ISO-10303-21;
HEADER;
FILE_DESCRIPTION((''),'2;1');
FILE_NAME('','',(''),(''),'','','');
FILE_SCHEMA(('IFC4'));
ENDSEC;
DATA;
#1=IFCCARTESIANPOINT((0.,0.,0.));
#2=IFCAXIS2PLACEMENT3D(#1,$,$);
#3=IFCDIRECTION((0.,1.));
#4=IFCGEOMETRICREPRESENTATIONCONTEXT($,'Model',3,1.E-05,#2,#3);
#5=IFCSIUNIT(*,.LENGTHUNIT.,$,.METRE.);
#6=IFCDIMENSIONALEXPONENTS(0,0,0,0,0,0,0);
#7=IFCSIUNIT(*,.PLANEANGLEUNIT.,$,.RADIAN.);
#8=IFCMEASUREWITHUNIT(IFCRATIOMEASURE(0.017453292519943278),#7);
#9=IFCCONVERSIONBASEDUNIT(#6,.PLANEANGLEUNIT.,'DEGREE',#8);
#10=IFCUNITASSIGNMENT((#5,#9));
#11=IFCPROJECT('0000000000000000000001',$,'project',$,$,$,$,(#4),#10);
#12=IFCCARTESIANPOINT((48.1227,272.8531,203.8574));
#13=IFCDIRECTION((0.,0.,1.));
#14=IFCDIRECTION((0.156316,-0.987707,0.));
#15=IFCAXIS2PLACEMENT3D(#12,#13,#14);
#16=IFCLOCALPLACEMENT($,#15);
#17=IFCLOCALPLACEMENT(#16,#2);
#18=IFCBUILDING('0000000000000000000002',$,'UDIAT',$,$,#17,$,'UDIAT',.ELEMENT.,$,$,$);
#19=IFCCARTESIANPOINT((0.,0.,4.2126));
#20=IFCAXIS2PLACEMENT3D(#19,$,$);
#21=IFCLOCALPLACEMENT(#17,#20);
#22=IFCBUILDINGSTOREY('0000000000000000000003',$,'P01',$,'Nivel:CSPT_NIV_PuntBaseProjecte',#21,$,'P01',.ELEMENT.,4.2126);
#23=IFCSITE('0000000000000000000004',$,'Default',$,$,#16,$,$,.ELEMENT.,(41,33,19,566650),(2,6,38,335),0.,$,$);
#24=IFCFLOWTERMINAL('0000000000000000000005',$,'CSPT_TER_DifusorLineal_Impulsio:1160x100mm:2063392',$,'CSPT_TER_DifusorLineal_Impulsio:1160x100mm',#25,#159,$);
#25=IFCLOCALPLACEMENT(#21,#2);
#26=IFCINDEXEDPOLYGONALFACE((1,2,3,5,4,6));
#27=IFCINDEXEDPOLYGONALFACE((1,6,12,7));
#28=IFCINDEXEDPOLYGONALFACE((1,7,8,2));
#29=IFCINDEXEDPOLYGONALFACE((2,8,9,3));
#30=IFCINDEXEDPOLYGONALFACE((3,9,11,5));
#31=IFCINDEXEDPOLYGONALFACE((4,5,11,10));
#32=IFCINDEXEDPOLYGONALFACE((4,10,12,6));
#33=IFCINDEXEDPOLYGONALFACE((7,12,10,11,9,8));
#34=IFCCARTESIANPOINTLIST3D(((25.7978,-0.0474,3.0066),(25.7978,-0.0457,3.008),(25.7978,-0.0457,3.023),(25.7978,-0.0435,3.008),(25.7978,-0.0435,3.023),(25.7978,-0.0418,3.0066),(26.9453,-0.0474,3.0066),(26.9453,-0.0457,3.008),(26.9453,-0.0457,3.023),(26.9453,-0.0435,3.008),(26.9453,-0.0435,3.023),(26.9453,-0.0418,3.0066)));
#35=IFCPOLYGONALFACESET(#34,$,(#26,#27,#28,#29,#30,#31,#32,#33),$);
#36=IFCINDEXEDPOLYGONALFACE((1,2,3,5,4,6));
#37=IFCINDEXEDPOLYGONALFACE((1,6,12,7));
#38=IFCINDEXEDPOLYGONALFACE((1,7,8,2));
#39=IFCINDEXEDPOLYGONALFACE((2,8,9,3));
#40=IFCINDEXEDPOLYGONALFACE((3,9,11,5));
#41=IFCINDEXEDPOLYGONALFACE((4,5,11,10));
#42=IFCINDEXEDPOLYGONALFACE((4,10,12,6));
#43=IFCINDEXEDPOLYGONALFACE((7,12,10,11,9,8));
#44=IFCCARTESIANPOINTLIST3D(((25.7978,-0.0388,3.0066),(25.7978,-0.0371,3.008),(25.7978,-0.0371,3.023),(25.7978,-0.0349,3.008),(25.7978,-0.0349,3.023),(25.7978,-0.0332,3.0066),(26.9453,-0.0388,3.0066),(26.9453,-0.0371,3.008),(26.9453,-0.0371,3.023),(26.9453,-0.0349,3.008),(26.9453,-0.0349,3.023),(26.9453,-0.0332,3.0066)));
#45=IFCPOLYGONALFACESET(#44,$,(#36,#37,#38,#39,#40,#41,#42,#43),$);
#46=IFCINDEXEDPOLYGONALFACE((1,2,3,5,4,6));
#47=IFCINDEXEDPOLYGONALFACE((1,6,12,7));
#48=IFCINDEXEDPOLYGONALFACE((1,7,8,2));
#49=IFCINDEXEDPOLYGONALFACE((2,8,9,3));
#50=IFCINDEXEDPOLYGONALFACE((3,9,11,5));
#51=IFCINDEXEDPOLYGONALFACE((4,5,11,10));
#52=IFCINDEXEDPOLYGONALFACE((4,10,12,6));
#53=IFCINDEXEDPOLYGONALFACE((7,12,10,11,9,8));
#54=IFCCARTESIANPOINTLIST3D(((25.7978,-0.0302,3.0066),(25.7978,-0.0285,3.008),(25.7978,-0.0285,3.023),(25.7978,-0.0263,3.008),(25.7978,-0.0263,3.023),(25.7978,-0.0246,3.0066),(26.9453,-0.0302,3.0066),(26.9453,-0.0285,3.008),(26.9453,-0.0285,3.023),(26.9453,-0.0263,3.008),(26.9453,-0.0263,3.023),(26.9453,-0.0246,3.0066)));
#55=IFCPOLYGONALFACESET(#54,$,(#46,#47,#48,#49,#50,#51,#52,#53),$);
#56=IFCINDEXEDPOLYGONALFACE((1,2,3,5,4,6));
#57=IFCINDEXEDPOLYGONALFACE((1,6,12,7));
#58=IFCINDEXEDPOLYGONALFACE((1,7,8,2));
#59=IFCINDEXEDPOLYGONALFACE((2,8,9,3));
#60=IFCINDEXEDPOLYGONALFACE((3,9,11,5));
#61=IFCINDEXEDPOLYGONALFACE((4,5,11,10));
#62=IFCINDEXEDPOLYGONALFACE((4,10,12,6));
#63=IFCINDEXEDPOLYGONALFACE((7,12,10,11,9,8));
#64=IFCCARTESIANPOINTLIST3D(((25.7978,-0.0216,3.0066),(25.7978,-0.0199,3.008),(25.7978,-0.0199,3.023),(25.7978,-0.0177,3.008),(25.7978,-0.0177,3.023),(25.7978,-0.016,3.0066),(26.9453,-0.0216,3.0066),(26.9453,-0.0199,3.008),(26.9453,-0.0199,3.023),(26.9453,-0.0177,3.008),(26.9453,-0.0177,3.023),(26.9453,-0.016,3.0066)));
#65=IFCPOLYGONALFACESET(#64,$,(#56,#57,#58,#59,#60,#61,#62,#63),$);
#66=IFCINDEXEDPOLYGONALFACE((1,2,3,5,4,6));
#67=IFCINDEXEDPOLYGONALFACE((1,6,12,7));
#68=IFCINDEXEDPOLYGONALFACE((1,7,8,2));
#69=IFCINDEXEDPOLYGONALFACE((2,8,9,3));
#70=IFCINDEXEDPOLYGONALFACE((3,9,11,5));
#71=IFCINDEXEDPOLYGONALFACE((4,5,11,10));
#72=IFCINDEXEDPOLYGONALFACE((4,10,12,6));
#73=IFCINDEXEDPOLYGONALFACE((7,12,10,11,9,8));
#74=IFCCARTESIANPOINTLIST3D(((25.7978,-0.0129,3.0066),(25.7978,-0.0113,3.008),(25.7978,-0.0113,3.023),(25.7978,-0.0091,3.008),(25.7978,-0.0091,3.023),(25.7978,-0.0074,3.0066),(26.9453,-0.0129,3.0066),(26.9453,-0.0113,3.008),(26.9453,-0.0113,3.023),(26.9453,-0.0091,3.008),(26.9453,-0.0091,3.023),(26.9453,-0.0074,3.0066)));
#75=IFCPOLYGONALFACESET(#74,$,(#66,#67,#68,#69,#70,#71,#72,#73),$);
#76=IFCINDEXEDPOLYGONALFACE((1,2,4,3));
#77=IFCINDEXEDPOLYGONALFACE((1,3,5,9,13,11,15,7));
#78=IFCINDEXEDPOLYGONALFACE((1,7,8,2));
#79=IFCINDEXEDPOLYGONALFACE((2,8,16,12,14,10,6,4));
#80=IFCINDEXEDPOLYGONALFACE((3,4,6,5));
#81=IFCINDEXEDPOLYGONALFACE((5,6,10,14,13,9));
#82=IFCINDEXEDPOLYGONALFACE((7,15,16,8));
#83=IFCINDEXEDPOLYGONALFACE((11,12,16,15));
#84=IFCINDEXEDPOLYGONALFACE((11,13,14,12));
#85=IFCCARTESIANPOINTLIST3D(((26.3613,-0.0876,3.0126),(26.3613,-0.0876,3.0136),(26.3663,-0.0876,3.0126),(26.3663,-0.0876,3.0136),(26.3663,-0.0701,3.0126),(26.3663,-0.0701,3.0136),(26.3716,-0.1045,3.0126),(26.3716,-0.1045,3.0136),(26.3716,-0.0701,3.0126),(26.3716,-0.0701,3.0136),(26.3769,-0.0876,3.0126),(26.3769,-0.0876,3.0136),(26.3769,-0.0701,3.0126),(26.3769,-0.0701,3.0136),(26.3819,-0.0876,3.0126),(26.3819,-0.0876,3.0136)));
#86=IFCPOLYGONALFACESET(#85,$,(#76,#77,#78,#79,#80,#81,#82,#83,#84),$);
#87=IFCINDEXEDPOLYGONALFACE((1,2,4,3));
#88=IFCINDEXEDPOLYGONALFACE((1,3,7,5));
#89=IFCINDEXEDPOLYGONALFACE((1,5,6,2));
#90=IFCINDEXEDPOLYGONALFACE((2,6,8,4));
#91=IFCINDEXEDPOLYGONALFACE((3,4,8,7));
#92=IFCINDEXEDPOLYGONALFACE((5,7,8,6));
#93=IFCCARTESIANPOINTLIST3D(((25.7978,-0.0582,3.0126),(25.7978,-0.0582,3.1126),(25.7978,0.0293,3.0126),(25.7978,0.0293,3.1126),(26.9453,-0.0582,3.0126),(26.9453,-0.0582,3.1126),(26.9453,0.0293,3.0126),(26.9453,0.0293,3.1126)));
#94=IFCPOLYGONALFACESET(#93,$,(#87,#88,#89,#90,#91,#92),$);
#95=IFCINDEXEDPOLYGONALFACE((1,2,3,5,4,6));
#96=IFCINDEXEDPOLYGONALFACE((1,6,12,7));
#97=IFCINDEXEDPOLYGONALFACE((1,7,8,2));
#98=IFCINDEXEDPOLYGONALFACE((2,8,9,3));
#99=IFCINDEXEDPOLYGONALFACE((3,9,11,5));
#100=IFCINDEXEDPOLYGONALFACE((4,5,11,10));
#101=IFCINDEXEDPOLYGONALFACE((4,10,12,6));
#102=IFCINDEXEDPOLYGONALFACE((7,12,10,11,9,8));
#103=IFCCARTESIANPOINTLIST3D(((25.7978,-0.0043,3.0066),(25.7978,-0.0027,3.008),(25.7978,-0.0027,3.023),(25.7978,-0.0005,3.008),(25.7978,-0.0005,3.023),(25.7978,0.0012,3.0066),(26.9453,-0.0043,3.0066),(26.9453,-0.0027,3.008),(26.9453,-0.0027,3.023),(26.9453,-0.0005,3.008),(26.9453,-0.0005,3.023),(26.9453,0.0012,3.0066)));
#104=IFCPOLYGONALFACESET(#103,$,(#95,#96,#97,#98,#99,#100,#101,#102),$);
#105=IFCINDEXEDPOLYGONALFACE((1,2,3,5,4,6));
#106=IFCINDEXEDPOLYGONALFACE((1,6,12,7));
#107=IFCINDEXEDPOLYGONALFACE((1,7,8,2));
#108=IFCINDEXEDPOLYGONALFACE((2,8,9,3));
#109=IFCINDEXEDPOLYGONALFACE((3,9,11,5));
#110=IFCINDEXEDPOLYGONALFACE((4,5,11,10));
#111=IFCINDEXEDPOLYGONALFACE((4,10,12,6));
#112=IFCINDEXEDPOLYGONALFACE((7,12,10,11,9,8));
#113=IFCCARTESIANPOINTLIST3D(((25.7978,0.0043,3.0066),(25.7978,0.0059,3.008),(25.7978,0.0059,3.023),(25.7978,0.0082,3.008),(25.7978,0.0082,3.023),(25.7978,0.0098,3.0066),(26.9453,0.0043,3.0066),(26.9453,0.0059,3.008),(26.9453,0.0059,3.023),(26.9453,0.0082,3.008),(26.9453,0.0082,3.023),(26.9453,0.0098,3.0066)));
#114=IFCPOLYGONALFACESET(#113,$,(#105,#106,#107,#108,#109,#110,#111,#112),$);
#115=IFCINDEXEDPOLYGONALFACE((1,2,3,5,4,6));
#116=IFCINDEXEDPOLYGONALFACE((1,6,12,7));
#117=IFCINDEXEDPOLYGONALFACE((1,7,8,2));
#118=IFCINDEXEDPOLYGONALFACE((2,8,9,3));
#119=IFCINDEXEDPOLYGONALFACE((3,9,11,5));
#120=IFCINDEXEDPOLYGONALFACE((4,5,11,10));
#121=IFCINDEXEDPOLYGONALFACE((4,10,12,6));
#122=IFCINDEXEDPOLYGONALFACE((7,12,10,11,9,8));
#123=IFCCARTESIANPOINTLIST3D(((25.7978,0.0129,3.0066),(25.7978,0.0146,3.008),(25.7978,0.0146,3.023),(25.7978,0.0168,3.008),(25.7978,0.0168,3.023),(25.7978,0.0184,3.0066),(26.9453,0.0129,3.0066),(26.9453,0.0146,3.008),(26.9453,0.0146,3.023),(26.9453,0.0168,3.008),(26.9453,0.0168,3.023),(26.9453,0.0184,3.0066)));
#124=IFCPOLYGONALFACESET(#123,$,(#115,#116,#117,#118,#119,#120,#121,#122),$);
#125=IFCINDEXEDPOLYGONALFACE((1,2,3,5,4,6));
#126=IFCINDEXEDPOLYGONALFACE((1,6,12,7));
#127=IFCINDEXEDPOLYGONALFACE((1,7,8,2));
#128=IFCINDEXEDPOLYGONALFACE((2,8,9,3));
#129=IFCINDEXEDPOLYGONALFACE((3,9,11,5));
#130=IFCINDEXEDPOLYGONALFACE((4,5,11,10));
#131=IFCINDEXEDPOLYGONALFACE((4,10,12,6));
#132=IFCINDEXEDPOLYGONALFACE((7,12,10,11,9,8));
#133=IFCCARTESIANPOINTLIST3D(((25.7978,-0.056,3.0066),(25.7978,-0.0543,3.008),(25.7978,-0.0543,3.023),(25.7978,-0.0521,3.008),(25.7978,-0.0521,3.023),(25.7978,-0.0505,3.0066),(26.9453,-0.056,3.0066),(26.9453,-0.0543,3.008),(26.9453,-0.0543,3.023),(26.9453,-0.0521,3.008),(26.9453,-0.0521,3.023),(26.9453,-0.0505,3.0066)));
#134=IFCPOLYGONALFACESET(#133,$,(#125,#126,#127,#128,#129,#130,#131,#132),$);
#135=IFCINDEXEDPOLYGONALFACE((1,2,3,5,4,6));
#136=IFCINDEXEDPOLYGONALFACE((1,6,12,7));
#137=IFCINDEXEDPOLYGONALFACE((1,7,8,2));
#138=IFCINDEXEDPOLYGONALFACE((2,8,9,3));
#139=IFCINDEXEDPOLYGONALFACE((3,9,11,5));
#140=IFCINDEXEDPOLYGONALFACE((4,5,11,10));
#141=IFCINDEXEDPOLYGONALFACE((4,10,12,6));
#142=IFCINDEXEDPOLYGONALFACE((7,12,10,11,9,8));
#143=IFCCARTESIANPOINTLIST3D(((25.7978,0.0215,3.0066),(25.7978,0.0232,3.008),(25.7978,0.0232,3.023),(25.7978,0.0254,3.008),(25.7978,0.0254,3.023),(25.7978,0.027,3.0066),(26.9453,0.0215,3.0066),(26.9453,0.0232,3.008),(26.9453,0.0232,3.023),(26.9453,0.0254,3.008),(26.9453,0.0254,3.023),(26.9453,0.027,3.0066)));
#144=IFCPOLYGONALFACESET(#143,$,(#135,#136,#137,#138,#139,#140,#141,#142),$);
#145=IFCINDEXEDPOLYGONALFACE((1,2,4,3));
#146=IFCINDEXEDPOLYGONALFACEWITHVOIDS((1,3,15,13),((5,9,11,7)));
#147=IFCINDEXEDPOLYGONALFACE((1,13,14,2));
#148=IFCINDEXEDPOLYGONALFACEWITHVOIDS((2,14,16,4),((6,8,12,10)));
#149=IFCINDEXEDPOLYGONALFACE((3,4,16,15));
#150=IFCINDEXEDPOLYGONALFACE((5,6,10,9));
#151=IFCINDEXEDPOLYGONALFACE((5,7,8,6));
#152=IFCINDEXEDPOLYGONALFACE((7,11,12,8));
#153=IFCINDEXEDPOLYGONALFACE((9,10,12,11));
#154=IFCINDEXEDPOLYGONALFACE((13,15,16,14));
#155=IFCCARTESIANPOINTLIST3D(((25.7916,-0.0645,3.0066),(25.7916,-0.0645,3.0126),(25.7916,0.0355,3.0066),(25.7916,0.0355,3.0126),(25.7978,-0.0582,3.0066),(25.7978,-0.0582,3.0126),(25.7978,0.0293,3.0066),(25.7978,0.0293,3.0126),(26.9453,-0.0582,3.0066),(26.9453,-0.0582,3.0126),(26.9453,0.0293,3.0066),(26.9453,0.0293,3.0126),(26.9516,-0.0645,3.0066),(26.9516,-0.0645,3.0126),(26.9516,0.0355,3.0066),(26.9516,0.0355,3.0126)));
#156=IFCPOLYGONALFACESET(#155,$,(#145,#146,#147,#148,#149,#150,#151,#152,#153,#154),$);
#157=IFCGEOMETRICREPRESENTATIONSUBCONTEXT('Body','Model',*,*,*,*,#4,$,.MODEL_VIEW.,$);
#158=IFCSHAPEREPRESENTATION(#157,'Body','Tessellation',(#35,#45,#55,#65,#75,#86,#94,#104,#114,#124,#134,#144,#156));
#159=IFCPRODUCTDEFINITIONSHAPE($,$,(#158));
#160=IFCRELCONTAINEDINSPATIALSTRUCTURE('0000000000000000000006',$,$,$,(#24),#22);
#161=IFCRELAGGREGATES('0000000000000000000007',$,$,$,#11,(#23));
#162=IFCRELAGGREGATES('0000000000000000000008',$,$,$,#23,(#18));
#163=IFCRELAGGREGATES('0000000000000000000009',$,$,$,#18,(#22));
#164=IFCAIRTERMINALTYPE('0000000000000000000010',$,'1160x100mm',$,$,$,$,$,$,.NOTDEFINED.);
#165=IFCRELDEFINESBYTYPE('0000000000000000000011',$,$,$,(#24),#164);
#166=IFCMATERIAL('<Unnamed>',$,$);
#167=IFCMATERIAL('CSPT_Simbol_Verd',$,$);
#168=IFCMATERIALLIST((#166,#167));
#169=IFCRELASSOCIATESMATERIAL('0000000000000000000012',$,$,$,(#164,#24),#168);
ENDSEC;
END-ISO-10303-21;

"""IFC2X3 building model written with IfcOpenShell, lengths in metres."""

from ifc_helpers import new_model, entity, si_unit, converted_unit, direction, frame, origin, origin_2d_with_axis, place, context, subcontext, project, spatial, polyline, rectangle, outline, extrude, source, transform, mapped, material, material_list, type_object, type_shapes, element, save


model = new_model("IFC2X3")

# Units and contexts
model_context = context("Model", 3, precision=1e-05, world=origin(), true_north=direction((0.0, 1.0)))
body_context = subcontext(model_context, "Body", "Model", "MODEL_VIEW")
ifc_project = project(units=[si_unit("LENGTHUNIT", "METRE"), converted_unit("PLANEANGLEUNIT", "DEGREE", entity("IfcRatioMeasure", 0.017453292519943278), si_unit("PLANEANGLEUNIT", "RADIAN"), dimensions=[0, 0, 0, 0, 0, 0, 0])], contexts=[model_context])

# Site, building, storey
site_placement = place(None, frame((48.1227, 272.8531, 203.8574), z_axis=(0.0, 0.0, 1.0), x_axis=(0.156316, -0.987707, 0.0)))
site = spatial("IfcSite", under=ifc_project, at=site_placement, Name="Default", CompositionType="ELEMENT", RefLatitude=(41, 33, 19, 566650), RefLongitude=(2, 6, 38, 335), RefElevation=0.0)
building_placement = place(site_placement, origin())
building = spatial("IfcBuilding", under=site, at=building_placement, Name="UDIAT", LongName="UDIAT", CompositionType="ELEMENT")
storey_placement = place(building_placement, frame((0.0, 0.0, 4.2126)))
storey = spatial("IfcBuildingStorey", under=building, at=storey_placement, Name="P01", ObjectType="Nivel:CSPT_NIV_PuntBaseProjecte", LongName="P01", CompositionType="ELEMENT", Elevation=4.2126)

# Shared definitions
ifc_material_1 = material(Name="<Unnamed>")

# Flow terminal
ifc_material_2 = material(Name="CSPT_Simbol_Verd")
ifc_material_list = material_list([ifc_material_1, ifc_material_2])
air_terminal_type = type_object("IfcAirTerminalType", Name="1160x100mm", PredefinedType="NOTDEFINED", material=ifc_material_list)
shared_shape_1 = source(origin(), body_context, "Body", "SweptSolid", [
    extrude(outline(polyline([(0.0037, 0.0028), (0.0059, 0.0028), (0.0016, 0.0063), (0.002, 0.0042), (-0.0074, -0.0074), (-0.0057, -0.0088), (0.0037, 0.0028)])), frame((-0.5737, 0.0301, -0.0001), z_axis=(1.0, 0.0, 0.0), x_axis=(0.0, -0.776119, -0.630587)), (0.0, 0.0, 1.0), 1.1475),
    extrude(outline(polyline([(0.0037, 0.0028), (0.0059, 0.0028), (0.0016, 0.0063), (0.002, 0.0042), (-0.0074, -0.0074), (-0.0057, -0.0088), (0.0037, 0.0028)])), frame((-0.5737, 0.0215, -0.0001), z_axis=(1.0, 0.0, 0.0), x_axis=(0.0, -0.776119, -0.630587)), (0.0, 0.0, 1.0), 1.1475),
    extrude(outline(polyline([(0.0037, 0.0028), (0.0059, 0.0028), (0.0016, 0.0063), (0.002, 0.0042), (-0.0074, -0.0074), (-0.0057, -0.0088), (0.0037, 0.0028)])), frame((-0.5737, 0.0129, -0.0001), z_axis=(1.0, 0.0, 0.0), x_axis=(0.0, -0.776119, -0.630587)), (0.0, 0.0, 1.0), 1.1475),
    extrude(outline(polyline([(0.0037, 0.0028), (0.0059, 0.0028), (0.0016, 0.0063), (0.002, 0.0042), (-0.0074, -0.0074), (-0.0057, -0.0088), (0.0037, 0.0028)])), frame((-0.5737, 0.0043, -0.0001), z_axis=(1.0, 0.0, 0.0), x_axis=(0.0, -0.776119, -0.630587)), (0.0, 0.0, 1.0), 1.1475),
    extrude(outline(polyline([(0.0037, 0.0028), (0.0059, 0.0028), (0.0016, 0.0063), (0.002, 0.0042), (-0.0074, -0.0074), (-0.0057, -0.0088), (0.0037, 0.0028)])), frame((-0.5737, -0.0043, -0.0001), z_axis=(1.0, 0.0, 0.0), x_axis=(0.0, -0.776119, -0.630587)), (0.0, 0.0, 1.0), 1.1475),
    extrude(outline(polyline([(0.0, -0.013), (0.0053, -0.013), (0.0053, 0.0045), (0.0103, 0.0045), (0.0, 0.0213), (-0.0103, 0.0045), (-0.0053, 0.0045), (-0.0053, -0.013), (0.0, -0.013)])), frame((0.0, 0.0687, 0.0)), (0.0, 0.0, 1.0), 0.001),
    extrude(rectangle(XDim=1.1475, YDim=0.0875, at=origin_2d_with_axis()), frame((0.0, 0.0, 0.0), z_axis=(0.0, 0.0, 1.0), x_axis=(-1.0, 0.0, 0.0)), (0.0, 0.0, 1.0), 0.1),
    extrude(outline(polyline([(0.0037, 0.0028), (0.0059, 0.0028), (0.0016, 0.0063), (0.002, 0.0042), (-0.0074, -0.0074), (-0.0057, -0.0088), (0.0037, 0.0028)])), frame((-0.5737, -0.0129, -0.0001), z_axis=(1.0, 0.0, 0.0), x_axis=(0.0, -0.776119, -0.630587)), (0.0, 0.0, 1.0), 1.1475),
    extrude(outline(polyline([(0.0037, 0.0028), (0.0059, 0.0028), (0.0016, 0.0063), (0.002, 0.0042), (-0.0074, -0.0074), (-0.0057, -0.0088), (0.0037, 0.0028)])), frame((-0.5737, -0.0215, -0.0001), z_axis=(1.0, 0.0, 0.0), x_axis=(0.0, -0.776119, -0.630587)), (0.0, 0.0, 1.0), 1.1475),
    extrude(outline(polyline([(0.0037, 0.0028), (0.0059, 0.0028), (0.0016, 0.0063), (0.002, 0.0042), (-0.0074, -0.0074), (-0.0057, -0.0088), (0.0037, 0.0028)])), frame((-0.5737, -0.0301, -0.0001), z_axis=(1.0, 0.0, 0.0), x_axis=(0.0, -0.776119, -0.630587)), (0.0, 0.0, 1.0), 1.1475),
    extrude(outline(polyline([(0.0037, 0.0028), (0.0059, 0.0028), (0.0016, 0.0063), (0.002, 0.0042), (-0.0074, -0.0074), (-0.0057, -0.0088), (0.0037, 0.0028)])), frame((-0.5737, 0.0388, -0.0001), z_axis=(1.0, 0.0, 0.0), x_axis=(0.0, -0.776119, -0.630587)), (0.0, 0.0, 1.0), 1.1475),
    extrude(outline(polyline([(0.0037, 0.0028), (0.0059, 0.0028), (0.0016, 0.0063), (0.002, 0.0042), (-0.0074, -0.0074), (-0.0057, -0.0088), (0.0037, 0.0028)])), frame((-0.5737, -0.0387, -0.0001), z_axis=(1.0, 0.0, 0.0), x_axis=(0.0, -0.776119, -0.630587)), (0.0, 0.0, 1.0), 1.1475),
    extrude(outline(polyline([(-0.58, -0.05), (0.58, -0.05), (0.58, 0.05), (-0.58, 0.05), (-0.58, -0.05)]), holes=[polyline([(-0.5738, -0.0438), (-0.5738, 0.0437), (0.5737, 0.0437), (0.5737, -0.0438), (-0.5738, -0.0438)])]), frame((0.0, 0.0, -0.006), z_axis=(0.0, 0.0, 1.0), x_axis=(-1.0, 0.0, 0.0)), (0.0, 0.0, 1.0), 0.006),
])
type_shapes(air_terminal_type, [shared_shape_1])
for number, where, z_axis, x_axis, name in (
    (1, (26.3716, -0.0145, 3.0126), (0.0, 0.0, 1.0), (-1.0, 0.0, 0.0), "CSPT_TER_DifusorLineal_Impulsio:1160x100mm:2063392"),
):
    element("IfcFlowTerminal", number, at=place(storey_placement, frame(where, z_axis=z_axis, x_axis=x_axis)), inside=storey, type_object=air_terminal_type, material=ifc_material_list, Name=name, ObjectType="CSPT_TER_DifusorLineal_Impulsio:1160x100mm", context=body_context, shape_type="MappedRepresentation", body=[
        mapped(shared_shape_1, transform((0.0, 0.0, 0.0), scale=1.0)),
    ])

save(model, "model.ifc")
